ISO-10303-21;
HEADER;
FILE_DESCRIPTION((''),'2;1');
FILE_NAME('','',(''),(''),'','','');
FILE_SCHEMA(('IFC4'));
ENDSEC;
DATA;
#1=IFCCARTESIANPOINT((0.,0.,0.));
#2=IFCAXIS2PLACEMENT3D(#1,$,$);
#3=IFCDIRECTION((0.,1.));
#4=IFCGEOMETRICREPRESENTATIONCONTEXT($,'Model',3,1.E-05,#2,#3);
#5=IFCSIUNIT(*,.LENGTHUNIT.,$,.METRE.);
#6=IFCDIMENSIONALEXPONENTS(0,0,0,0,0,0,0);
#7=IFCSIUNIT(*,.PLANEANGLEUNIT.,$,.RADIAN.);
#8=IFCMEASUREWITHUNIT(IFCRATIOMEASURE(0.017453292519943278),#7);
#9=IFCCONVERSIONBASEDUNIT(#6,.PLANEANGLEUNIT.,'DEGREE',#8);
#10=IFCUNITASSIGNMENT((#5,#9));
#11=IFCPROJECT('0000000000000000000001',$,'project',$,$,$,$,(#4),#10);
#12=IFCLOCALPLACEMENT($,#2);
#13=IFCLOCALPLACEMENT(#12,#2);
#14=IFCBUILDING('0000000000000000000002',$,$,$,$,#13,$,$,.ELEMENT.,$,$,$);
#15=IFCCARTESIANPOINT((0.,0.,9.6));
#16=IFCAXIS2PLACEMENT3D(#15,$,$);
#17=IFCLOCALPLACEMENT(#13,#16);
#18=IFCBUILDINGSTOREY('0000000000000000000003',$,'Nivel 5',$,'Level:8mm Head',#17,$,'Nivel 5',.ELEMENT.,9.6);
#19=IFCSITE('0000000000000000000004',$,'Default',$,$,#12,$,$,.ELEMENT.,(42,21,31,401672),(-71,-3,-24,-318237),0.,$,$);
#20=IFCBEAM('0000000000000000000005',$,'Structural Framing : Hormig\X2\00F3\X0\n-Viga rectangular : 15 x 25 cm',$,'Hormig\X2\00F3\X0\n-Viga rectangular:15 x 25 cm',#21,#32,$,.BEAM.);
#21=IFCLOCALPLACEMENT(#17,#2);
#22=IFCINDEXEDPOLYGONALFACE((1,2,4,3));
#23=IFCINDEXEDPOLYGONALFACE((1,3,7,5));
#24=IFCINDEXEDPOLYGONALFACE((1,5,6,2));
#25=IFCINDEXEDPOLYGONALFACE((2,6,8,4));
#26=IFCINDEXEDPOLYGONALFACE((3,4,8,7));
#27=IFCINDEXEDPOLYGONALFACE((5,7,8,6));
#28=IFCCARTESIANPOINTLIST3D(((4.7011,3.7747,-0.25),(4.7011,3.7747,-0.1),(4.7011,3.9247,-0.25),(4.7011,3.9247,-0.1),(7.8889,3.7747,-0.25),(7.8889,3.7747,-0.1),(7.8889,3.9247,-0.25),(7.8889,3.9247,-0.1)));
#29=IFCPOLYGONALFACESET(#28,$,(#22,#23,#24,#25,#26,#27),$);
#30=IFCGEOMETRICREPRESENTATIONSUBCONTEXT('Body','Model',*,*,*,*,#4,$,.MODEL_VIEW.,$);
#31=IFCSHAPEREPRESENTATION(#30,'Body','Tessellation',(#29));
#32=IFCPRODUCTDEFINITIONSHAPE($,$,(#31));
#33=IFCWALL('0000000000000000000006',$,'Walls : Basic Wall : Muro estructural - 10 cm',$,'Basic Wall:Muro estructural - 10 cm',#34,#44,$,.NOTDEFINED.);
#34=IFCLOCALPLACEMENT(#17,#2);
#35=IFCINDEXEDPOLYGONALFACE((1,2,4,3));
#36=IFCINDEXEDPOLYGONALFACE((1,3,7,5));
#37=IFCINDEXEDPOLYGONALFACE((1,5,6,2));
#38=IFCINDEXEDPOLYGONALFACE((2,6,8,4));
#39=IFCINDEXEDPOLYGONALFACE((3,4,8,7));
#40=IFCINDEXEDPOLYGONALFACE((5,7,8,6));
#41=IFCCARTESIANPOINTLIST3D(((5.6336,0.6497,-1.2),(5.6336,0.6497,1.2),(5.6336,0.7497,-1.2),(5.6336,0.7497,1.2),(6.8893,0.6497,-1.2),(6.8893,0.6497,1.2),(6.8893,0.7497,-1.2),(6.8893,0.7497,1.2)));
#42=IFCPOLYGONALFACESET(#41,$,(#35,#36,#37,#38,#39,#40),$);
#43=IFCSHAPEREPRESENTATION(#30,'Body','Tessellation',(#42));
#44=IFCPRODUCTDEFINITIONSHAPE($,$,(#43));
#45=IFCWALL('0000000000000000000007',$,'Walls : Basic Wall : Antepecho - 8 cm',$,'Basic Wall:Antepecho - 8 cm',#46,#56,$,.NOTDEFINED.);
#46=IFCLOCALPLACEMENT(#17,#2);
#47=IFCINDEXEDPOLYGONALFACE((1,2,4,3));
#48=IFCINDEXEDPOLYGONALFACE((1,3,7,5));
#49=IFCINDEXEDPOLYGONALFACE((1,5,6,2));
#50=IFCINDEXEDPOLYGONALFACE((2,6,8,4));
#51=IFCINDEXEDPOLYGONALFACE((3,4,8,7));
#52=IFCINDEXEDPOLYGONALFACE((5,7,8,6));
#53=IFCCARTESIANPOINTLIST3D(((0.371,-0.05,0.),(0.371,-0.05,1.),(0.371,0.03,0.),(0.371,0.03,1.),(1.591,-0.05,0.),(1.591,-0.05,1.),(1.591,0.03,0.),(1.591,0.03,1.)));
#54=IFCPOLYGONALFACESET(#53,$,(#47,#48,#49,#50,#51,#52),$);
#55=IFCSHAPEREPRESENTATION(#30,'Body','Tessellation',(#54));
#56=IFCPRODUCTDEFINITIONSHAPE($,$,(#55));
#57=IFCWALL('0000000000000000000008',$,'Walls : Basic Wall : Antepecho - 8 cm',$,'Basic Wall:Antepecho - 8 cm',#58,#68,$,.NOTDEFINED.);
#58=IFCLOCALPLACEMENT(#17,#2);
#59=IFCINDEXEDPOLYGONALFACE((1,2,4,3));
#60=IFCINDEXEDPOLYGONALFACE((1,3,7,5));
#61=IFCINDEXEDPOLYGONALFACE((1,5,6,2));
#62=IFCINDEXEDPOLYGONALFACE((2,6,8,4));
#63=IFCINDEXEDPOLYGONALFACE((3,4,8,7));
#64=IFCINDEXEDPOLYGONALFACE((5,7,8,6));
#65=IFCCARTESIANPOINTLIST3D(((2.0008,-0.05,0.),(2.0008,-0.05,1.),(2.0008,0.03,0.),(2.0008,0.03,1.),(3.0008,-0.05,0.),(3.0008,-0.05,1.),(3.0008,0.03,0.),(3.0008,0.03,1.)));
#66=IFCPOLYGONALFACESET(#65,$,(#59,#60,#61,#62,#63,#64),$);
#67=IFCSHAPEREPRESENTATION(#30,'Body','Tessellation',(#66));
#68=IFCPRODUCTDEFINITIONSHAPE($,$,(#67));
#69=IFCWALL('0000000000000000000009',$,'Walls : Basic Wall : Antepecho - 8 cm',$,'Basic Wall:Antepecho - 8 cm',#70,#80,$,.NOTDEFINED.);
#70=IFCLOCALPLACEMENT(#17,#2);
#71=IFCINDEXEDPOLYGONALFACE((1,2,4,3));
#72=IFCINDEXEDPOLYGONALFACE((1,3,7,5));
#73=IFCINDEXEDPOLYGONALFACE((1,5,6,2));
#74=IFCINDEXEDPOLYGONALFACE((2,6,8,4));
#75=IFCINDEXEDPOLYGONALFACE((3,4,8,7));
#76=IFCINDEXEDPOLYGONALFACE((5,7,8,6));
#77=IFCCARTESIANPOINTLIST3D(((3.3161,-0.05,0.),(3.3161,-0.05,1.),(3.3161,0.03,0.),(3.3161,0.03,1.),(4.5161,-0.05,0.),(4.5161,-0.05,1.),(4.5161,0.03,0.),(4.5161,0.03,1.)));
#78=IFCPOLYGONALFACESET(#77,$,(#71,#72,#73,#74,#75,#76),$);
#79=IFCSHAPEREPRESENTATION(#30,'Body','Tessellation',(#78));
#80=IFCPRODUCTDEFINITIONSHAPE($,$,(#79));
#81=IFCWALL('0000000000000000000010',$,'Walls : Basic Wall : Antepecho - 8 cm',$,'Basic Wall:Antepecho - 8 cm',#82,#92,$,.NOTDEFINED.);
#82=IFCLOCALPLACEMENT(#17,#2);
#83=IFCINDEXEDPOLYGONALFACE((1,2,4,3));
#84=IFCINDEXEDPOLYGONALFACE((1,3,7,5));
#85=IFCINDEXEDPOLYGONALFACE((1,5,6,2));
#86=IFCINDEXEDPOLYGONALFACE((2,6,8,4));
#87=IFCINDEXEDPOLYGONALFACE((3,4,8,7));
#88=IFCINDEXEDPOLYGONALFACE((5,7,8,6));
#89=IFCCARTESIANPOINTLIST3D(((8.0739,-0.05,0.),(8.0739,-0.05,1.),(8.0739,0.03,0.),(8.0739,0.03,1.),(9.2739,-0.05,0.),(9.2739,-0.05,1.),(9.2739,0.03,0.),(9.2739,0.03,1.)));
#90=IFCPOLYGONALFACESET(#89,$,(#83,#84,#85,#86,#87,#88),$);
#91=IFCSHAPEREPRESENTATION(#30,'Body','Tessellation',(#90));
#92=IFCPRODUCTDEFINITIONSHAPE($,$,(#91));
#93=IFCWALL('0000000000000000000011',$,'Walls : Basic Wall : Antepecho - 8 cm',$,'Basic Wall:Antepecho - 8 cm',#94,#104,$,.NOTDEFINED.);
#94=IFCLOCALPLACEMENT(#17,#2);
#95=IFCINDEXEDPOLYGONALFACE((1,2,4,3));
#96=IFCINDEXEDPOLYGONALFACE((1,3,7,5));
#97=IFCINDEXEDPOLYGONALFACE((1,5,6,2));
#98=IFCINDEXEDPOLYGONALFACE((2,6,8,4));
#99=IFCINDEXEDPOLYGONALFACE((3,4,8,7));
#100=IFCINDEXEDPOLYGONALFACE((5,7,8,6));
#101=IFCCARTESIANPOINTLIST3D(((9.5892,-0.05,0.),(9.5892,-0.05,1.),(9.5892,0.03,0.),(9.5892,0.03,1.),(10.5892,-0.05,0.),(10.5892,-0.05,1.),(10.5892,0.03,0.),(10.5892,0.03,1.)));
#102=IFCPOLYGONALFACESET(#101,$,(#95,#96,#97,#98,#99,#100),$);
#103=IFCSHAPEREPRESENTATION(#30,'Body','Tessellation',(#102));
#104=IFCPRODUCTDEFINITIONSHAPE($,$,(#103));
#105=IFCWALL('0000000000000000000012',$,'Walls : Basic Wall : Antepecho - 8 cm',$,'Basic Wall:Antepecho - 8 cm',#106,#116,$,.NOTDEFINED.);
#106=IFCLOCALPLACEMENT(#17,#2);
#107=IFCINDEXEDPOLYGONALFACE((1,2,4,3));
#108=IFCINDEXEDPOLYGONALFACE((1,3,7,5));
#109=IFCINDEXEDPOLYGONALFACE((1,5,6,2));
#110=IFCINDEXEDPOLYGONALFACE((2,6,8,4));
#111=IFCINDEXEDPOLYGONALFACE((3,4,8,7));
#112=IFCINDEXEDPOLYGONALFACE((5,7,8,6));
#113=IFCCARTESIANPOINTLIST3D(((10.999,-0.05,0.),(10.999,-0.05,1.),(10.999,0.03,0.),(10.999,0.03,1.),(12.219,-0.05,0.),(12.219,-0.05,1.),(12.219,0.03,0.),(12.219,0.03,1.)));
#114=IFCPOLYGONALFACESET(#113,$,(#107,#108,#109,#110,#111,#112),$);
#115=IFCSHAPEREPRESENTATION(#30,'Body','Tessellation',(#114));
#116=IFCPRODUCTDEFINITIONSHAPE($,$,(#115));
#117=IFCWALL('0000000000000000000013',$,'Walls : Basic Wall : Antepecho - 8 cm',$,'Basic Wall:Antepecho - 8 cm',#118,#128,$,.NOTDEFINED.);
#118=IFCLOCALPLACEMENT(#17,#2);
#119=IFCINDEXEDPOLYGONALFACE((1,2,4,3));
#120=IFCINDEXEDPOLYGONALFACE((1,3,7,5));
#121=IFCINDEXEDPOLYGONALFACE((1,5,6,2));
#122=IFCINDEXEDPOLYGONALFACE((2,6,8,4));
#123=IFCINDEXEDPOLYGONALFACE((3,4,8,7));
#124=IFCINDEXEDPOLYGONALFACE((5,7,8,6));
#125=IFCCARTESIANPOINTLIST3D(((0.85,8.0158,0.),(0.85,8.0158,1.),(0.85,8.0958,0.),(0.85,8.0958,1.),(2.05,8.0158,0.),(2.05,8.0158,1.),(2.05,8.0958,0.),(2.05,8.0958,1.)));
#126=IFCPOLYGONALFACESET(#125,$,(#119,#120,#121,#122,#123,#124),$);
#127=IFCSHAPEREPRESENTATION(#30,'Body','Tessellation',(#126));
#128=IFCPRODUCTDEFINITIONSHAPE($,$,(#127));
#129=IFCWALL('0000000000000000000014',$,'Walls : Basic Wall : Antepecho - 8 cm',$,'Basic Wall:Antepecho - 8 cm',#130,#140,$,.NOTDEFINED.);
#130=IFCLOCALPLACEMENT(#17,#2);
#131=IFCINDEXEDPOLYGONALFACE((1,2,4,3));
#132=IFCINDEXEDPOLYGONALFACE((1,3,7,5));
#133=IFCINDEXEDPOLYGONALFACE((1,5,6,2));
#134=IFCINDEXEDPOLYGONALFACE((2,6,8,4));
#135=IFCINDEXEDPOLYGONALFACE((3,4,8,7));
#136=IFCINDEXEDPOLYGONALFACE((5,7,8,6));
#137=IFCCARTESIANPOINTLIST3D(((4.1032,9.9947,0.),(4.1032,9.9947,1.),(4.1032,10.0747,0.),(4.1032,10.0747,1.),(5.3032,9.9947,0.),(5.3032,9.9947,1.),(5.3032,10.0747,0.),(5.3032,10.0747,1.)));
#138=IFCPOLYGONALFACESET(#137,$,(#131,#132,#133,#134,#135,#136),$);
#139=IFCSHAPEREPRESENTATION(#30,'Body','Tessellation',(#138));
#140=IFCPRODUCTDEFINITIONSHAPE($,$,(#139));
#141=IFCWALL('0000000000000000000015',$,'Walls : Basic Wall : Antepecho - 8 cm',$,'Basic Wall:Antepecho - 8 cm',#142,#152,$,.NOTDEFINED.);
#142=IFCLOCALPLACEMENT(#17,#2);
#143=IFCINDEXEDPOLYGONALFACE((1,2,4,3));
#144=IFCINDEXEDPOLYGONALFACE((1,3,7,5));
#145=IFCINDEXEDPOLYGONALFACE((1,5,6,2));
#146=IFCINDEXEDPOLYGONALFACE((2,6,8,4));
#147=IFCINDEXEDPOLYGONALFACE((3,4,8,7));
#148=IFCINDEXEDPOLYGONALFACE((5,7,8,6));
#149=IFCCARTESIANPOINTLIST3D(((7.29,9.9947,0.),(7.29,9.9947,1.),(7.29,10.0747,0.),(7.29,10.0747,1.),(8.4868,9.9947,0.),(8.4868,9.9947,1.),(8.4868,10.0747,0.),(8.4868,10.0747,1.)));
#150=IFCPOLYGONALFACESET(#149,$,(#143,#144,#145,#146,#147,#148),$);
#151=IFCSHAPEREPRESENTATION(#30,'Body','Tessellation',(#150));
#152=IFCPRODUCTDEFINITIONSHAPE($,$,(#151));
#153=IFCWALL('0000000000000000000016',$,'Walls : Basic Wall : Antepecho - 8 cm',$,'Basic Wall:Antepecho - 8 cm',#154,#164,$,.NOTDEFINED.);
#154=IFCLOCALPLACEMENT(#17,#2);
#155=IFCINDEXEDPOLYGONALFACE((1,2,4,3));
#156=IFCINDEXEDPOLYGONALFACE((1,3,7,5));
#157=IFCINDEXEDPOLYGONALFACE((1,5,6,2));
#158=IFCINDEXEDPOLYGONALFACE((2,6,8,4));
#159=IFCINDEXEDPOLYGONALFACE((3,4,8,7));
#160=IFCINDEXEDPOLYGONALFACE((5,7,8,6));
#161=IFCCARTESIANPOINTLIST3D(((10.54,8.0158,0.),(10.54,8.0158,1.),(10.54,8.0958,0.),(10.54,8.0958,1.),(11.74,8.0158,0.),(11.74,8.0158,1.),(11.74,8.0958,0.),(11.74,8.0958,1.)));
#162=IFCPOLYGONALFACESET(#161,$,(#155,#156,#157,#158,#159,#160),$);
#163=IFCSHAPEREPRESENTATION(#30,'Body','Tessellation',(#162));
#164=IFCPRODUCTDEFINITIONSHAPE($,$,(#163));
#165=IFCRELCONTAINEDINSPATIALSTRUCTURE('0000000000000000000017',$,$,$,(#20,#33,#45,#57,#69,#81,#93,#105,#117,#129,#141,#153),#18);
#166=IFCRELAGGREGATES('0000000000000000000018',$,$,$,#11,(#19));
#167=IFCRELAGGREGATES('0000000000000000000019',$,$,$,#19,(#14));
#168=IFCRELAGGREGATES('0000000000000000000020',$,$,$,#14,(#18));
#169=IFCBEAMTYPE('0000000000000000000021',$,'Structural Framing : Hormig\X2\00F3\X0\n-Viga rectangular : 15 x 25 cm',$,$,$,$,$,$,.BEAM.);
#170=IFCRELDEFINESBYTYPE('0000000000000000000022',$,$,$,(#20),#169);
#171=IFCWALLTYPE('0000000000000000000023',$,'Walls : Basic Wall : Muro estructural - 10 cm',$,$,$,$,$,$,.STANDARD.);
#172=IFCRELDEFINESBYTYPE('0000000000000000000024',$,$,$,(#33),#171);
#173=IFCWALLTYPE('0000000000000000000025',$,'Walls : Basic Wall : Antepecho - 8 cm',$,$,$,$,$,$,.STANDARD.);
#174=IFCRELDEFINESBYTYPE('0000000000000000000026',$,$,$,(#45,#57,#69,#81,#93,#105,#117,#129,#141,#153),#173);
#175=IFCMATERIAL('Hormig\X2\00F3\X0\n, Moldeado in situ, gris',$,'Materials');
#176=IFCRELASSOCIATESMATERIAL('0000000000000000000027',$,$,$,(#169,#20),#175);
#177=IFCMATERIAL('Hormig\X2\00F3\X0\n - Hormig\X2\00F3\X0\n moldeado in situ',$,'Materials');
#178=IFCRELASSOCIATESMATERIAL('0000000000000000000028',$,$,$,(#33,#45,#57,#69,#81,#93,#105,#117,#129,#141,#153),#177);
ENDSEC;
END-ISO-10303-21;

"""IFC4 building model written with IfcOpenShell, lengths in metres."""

from ifc_helpers import new_model, entity, si_unit, converted_unit, direction, frame, origin, place, context, subcontext, project, spatial, indexed_curve, outline, extrude, source, transform, mapped, material, type_object, type_shapes, element, save


model = new_model("IFC4")

# Units and contexts
model_context = context("Model", 3, precision=1e-05, world=origin(), true_north=direction((0.0, 1.0)))
body_context = subcontext(model_context, "Body", "Model", "MODEL_VIEW")
ifc_project = project(units=[si_unit("LENGTHUNIT", "METRE"), converted_unit("PLANEANGLEUNIT", "DEGREE", entity("IfcRatioMeasure", 0.017453292519943278), si_unit("PLANEANGLEUNIT", "RADIAN"), dimensions=[0, 0, 0, 0, 0, 0, 0])], contexts=[model_context])

# Site, building, storey
site_placement = place(None, origin())
site = spatial("IfcSite", under=ifc_project, at=site_placement, Name="Default", CompositionType="ELEMENT", RefLatitude=(42, 21, 31, 401672), RefLongitude=(-71, -3, -24, -318237), RefElevation=0.0)
building_placement = place(site_placement, origin())
building = spatial("IfcBuilding", under=site, at=building_placement, CompositionType="ELEMENT")
storey_placement = place(building_placement, frame((0.0, 0.0, 9.6)))
storey = spatial("IfcBuildingStorey", under=building, at=storey_placement, Name="Nivel 5", ObjectType="Level:8mm Head", LongName="Nivel 5", CompositionType="ELEMENT", Elevation=9.6)

# Beam
ifc_material_1 = material(Name="Hormigón, Moldeado in situ, gris", Category="Materials")
beam_type_1 = type_object("IfcBeamType", Name="Structural Framing : Hormigón-Viga rectangular : 15 x 25 cm", PredefinedType="BEAM", material=ifc_material_1)
shared_shape_1 = source(origin(), body_context, "Body", "SweptSolid", [
    extrude(outline(indexed_curve([(-0.075, -0.075), (0.075, -0.075), (0.075, 0.075), (-0.075, 0.075), (-0.075, -0.075)], self_intersect=False)), frame((4.7011, 3.8497, 9.425), z_axis=(1.0, 0.0, 0.0), x_axis=(0.0, 0.0, -1.0)), (0.0, 0.0, 1.0), 3.1878),
])
type_shapes(beam_type_1, [shared_shape_1])
beam_1_placement = place(storey_placement, frame((0.0, 0.0, -9.6)))
element("IfcBeam", 1, at=beam_1_placement, inside=storey, type_object=beam_type_1, material=ifc_material_1, Name="Structural Framing : Hormigón-Viga rectangular : 15 x 25 cm", ObjectType="Hormigón-Viga rectangular:15 x 25 cm", PredefinedType="BEAM", context=body_context, shape_type="MappedRepresentation", body=[
    mapped(shared_shape_1, transform((0.0, 0.0, 0.0), scale=1.0)),
])

# Shared definitions
ifc_material_2 = material(Name="Hormigón - Hormigón moldeado in situ", Category="Materials")

# Walls
wall_type_1 = type_object("IfcWallType", Name="Walls : Basic Wall : Muro estructural - 10 cm", PredefinedType="STANDARD")
wall_1_placement = place(storey_placement, frame((5.6336, 0.6997, -1.2)))
element("IfcWall", 2, at=wall_1_placement, inside=storey, type_object=wall_type_1, material=ifc_material_2, Name="Walls : Basic Wall : Muro estructural - 10 cm", ObjectType="Basic Wall:Muro estructural - 10 cm", PredefinedType="NOTDEFINED", context=body_context, shape_type="SweptSolid", body=[
    extrude(outline(indexed_curve([(1.2557, 0.05), (0.0, 0.05), (0.0, -0.05), (1.2557, -0.05), (1.2557, 0.05)], self_intersect=False)), origin(), (0.0, 0.0, 1.0), 2.4),
])
wall_type_2 = type_object("IfcWallType", Name="Walls : Basic Wall : Antepecho - 8 cm", PredefinedType="STANDARD")
wall_2_placement = place(storey_placement, frame((0.371, -0.01, 0.0)))
element("IfcWall", 3, at=wall_2_placement, inside=storey, type_object=wall_type_2, material=ifc_material_2, Name="Walls : Basic Wall : Antepecho - 8 cm", ObjectType="Basic Wall:Antepecho - 8 cm", PredefinedType="NOTDEFINED", context=body_context, shape_type="SweptSolid", body=[
    extrude(outline(indexed_curve([(1.22, 0.04), (0.0, 0.04), (0.0, -0.04), (1.22, -0.04), (1.22, 0.04)], self_intersect=False)), origin(), (0.0, 0.0, 1.0), 1.0),
])
wall_3_placement = place(storey_placement, frame((2.0008, -0.01, 0.0)))
element("IfcWall", 4, at=wall_3_placement, inside=storey, type_object=wall_type_2, material=ifc_material_2, Name="Walls : Basic Wall : Antepecho - 8 cm", ObjectType="Basic Wall:Antepecho - 8 cm", PredefinedType="NOTDEFINED", context=body_context, shape_type="SweptSolid", body=[
    extrude(outline(indexed_curve([(1.0, 0.04), (0.0, 0.04), (0.0, -0.04), (1.0, -0.04), (1.0, 0.04)], self_intersect=False)), origin(), (0.0, 0.0, 1.0), 1.0),
])
wall_4_placement = place(storey_placement, frame((3.3161, -0.01, 0.0)))
element("IfcWall", 5, at=wall_4_placement, inside=storey, type_object=wall_type_2, material=ifc_material_2, Name="Walls : Basic Wall : Antepecho - 8 cm", ObjectType="Basic Wall:Antepecho - 8 cm", PredefinedType="NOTDEFINED", context=body_context, shape_type="SweptSolid", body=[
    extrude(outline(indexed_curve([(1.2, 0.04), (0.0, 0.04), (0.0, -0.04), (1.2, -0.04), (1.2, 0.04)], self_intersect=False)), origin(), (0.0, 0.0, 1.0), 1.0),
])
wall_5_placement = place(storey_placement, frame((8.0739, -0.01, 0.0)))
element("IfcWall", 6, at=wall_5_placement, inside=storey, type_object=wall_type_2, material=ifc_material_2, Name="Walls : Basic Wall : Antepecho - 8 cm", ObjectType="Basic Wall:Antepecho - 8 cm", PredefinedType="NOTDEFINED", context=body_context, shape_type="SweptSolid", body=[
    extrude(outline(indexed_curve([(1.2, 0.04), (0.0, 0.04), (0.0, -0.04), (1.2, -0.04), (1.2, 0.04)], self_intersect=False)), origin(), (0.0, 0.0, 1.0), 1.0),
])
wall_6_placement = place(storey_placement, frame((9.5892, -0.01, 0.0)))
element("IfcWall", 7, at=wall_6_placement, inside=storey, type_object=wall_type_2, material=ifc_material_2, Name="Walls : Basic Wall : Antepecho - 8 cm", ObjectType="Basic Wall:Antepecho - 8 cm", PredefinedType="NOTDEFINED", context=body_context, shape_type="SweptSolid", body=[
    extrude(outline(indexed_curve([(1.0, 0.04), (0.0, 0.04), (0.0, -0.04), (1.0, -0.04), (1.0, 0.04)], self_intersect=False)), origin(), (0.0, 0.0, 1.0), 1.0),
])
wall_7_placement = place(storey_placement, frame((10.999, -0.01, 0.0)))
element("IfcWall", 8, at=wall_7_placement, inside=storey, type_object=wall_type_2, material=ifc_material_2, Name="Walls : Basic Wall : Antepecho - 8 cm", ObjectType="Basic Wall:Antepecho - 8 cm", PredefinedType="NOTDEFINED", context=body_context, shape_type="SweptSolid", body=[
    extrude(outline(indexed_curve([(1.22, 0.04), (0.0, 0.04), (0.0, -0.04), (1.22, -0.04), (1.22, 0.04)], self_intersect=False)), origin(), (0.0, 0.0, 1.0), 1.0),
])
wall_8_placement = place(storey_placement, frame((2.05, 8.0558, 0.0), z_axis=(0.0, 0.0, 1.0), x_axis=(-1.0, 0.0, 0.0)))
element("IfcWall", 9, at=wall_8_placement, inside=storey, type_object=wall_type_2, material=ifc_material_2, Name="Walls : Basic Wall : Antepecho - 8 cm", ObjectType="Basic Wall:Antepecho - 8 cm", PredefinedType="NOTDEFINED", context=body_context, shape_type="SweptSolid", body=[
    extrude(outline(indexed_curve([(1.2, 0.04), (0.0, 0.04), (0.0, -0.04), (1.2, -0.04), (1.2, 0.04)], self_intersect=False)), origin(), (0.0, 0.0, 1.0), 1.0),
])
wall_9_placement = place(storey_placement, frame((5.3032, 10.0347, 0.0), z_axis=(0.0, 0.0, 1.0), x_axis=(-1.0, 0.0, 0.0)))
element("IfcWall", 10, at=wall_9_placement, inside=storey, type_object=wall_type_2, material=ifc_material_2, Name="Walls : Basic Wall : Antepecho - 8 cm", ObjectType="Basic Wall:Antepecho - 8 cm", PredefinedType="NOTDEFINED", context=body_context, shape_type="SweptSolid", body=[
    extrude(outline(indexed_curve([(1.2, 0.04), (0.0, 0.04), (0.0, -0.04), (1.2, -0.04), (1.2, 0.04)], self_intersect=False)), origin(), (0.0, 0.0, 1.0), 1.0),
])
wall_10_placement = place(storey_placement, frame((8.4868, 10.0347, 0.0), z_axis=(0.0, 0.0, 1.0), x_axis=(-1.0, 0.0, 0.0)))
element("IfcWall", 11, at=wall_10_placement, inside=storey, type_object=wall_type_2, material=ifc_material_2, Name="Walls : Basic Wall : Antepecho - 8 cm", ObjectType="Basic Wall:Antepecho - 8 cm", PredefinedType="NOTDEFINED", context=body_context, shape_type="SweptSolid", body=[
    extrude(outline(indexed_curve([(1.1968, 0.04), (0.0, 0.04), (0.0, -0.04), (1.1968, -0.04), (1.1968, 0.04)], self_intersect=False)), origin(), (0.0, 0.0, 1.0), 1.0),
])
wall_11_placement = place(storey_placement, frame((11.74, 8.0558, 0.0), z_axis=(0.0, 0.0, 1.0), x_axis=(-1.0, 0.0, 0.0)))
element("IfcWall", 12, at=wall_11_placement, inside=storey, type_object=wall_type_2, material=ifc_material_2, Name="Walls : Basic Wall : Antepecho - 8 cm", ObjectType="Basic Wall:Antepecho - 8 cm", PredefinedType="NOTDEFINED", context=body_context, shape_type="SweptSolid", body=[
    extrude(outline(indexed_curve([(1.2, 0.04), (0.0, 0.04), (0.0, -0.04), (1.2, -0.04), (1.2, 0.04)], self_intersect=False)), origin(), (0.0, 0.0, 1.0), 1.0),
])

save(model, "model.ifc")
